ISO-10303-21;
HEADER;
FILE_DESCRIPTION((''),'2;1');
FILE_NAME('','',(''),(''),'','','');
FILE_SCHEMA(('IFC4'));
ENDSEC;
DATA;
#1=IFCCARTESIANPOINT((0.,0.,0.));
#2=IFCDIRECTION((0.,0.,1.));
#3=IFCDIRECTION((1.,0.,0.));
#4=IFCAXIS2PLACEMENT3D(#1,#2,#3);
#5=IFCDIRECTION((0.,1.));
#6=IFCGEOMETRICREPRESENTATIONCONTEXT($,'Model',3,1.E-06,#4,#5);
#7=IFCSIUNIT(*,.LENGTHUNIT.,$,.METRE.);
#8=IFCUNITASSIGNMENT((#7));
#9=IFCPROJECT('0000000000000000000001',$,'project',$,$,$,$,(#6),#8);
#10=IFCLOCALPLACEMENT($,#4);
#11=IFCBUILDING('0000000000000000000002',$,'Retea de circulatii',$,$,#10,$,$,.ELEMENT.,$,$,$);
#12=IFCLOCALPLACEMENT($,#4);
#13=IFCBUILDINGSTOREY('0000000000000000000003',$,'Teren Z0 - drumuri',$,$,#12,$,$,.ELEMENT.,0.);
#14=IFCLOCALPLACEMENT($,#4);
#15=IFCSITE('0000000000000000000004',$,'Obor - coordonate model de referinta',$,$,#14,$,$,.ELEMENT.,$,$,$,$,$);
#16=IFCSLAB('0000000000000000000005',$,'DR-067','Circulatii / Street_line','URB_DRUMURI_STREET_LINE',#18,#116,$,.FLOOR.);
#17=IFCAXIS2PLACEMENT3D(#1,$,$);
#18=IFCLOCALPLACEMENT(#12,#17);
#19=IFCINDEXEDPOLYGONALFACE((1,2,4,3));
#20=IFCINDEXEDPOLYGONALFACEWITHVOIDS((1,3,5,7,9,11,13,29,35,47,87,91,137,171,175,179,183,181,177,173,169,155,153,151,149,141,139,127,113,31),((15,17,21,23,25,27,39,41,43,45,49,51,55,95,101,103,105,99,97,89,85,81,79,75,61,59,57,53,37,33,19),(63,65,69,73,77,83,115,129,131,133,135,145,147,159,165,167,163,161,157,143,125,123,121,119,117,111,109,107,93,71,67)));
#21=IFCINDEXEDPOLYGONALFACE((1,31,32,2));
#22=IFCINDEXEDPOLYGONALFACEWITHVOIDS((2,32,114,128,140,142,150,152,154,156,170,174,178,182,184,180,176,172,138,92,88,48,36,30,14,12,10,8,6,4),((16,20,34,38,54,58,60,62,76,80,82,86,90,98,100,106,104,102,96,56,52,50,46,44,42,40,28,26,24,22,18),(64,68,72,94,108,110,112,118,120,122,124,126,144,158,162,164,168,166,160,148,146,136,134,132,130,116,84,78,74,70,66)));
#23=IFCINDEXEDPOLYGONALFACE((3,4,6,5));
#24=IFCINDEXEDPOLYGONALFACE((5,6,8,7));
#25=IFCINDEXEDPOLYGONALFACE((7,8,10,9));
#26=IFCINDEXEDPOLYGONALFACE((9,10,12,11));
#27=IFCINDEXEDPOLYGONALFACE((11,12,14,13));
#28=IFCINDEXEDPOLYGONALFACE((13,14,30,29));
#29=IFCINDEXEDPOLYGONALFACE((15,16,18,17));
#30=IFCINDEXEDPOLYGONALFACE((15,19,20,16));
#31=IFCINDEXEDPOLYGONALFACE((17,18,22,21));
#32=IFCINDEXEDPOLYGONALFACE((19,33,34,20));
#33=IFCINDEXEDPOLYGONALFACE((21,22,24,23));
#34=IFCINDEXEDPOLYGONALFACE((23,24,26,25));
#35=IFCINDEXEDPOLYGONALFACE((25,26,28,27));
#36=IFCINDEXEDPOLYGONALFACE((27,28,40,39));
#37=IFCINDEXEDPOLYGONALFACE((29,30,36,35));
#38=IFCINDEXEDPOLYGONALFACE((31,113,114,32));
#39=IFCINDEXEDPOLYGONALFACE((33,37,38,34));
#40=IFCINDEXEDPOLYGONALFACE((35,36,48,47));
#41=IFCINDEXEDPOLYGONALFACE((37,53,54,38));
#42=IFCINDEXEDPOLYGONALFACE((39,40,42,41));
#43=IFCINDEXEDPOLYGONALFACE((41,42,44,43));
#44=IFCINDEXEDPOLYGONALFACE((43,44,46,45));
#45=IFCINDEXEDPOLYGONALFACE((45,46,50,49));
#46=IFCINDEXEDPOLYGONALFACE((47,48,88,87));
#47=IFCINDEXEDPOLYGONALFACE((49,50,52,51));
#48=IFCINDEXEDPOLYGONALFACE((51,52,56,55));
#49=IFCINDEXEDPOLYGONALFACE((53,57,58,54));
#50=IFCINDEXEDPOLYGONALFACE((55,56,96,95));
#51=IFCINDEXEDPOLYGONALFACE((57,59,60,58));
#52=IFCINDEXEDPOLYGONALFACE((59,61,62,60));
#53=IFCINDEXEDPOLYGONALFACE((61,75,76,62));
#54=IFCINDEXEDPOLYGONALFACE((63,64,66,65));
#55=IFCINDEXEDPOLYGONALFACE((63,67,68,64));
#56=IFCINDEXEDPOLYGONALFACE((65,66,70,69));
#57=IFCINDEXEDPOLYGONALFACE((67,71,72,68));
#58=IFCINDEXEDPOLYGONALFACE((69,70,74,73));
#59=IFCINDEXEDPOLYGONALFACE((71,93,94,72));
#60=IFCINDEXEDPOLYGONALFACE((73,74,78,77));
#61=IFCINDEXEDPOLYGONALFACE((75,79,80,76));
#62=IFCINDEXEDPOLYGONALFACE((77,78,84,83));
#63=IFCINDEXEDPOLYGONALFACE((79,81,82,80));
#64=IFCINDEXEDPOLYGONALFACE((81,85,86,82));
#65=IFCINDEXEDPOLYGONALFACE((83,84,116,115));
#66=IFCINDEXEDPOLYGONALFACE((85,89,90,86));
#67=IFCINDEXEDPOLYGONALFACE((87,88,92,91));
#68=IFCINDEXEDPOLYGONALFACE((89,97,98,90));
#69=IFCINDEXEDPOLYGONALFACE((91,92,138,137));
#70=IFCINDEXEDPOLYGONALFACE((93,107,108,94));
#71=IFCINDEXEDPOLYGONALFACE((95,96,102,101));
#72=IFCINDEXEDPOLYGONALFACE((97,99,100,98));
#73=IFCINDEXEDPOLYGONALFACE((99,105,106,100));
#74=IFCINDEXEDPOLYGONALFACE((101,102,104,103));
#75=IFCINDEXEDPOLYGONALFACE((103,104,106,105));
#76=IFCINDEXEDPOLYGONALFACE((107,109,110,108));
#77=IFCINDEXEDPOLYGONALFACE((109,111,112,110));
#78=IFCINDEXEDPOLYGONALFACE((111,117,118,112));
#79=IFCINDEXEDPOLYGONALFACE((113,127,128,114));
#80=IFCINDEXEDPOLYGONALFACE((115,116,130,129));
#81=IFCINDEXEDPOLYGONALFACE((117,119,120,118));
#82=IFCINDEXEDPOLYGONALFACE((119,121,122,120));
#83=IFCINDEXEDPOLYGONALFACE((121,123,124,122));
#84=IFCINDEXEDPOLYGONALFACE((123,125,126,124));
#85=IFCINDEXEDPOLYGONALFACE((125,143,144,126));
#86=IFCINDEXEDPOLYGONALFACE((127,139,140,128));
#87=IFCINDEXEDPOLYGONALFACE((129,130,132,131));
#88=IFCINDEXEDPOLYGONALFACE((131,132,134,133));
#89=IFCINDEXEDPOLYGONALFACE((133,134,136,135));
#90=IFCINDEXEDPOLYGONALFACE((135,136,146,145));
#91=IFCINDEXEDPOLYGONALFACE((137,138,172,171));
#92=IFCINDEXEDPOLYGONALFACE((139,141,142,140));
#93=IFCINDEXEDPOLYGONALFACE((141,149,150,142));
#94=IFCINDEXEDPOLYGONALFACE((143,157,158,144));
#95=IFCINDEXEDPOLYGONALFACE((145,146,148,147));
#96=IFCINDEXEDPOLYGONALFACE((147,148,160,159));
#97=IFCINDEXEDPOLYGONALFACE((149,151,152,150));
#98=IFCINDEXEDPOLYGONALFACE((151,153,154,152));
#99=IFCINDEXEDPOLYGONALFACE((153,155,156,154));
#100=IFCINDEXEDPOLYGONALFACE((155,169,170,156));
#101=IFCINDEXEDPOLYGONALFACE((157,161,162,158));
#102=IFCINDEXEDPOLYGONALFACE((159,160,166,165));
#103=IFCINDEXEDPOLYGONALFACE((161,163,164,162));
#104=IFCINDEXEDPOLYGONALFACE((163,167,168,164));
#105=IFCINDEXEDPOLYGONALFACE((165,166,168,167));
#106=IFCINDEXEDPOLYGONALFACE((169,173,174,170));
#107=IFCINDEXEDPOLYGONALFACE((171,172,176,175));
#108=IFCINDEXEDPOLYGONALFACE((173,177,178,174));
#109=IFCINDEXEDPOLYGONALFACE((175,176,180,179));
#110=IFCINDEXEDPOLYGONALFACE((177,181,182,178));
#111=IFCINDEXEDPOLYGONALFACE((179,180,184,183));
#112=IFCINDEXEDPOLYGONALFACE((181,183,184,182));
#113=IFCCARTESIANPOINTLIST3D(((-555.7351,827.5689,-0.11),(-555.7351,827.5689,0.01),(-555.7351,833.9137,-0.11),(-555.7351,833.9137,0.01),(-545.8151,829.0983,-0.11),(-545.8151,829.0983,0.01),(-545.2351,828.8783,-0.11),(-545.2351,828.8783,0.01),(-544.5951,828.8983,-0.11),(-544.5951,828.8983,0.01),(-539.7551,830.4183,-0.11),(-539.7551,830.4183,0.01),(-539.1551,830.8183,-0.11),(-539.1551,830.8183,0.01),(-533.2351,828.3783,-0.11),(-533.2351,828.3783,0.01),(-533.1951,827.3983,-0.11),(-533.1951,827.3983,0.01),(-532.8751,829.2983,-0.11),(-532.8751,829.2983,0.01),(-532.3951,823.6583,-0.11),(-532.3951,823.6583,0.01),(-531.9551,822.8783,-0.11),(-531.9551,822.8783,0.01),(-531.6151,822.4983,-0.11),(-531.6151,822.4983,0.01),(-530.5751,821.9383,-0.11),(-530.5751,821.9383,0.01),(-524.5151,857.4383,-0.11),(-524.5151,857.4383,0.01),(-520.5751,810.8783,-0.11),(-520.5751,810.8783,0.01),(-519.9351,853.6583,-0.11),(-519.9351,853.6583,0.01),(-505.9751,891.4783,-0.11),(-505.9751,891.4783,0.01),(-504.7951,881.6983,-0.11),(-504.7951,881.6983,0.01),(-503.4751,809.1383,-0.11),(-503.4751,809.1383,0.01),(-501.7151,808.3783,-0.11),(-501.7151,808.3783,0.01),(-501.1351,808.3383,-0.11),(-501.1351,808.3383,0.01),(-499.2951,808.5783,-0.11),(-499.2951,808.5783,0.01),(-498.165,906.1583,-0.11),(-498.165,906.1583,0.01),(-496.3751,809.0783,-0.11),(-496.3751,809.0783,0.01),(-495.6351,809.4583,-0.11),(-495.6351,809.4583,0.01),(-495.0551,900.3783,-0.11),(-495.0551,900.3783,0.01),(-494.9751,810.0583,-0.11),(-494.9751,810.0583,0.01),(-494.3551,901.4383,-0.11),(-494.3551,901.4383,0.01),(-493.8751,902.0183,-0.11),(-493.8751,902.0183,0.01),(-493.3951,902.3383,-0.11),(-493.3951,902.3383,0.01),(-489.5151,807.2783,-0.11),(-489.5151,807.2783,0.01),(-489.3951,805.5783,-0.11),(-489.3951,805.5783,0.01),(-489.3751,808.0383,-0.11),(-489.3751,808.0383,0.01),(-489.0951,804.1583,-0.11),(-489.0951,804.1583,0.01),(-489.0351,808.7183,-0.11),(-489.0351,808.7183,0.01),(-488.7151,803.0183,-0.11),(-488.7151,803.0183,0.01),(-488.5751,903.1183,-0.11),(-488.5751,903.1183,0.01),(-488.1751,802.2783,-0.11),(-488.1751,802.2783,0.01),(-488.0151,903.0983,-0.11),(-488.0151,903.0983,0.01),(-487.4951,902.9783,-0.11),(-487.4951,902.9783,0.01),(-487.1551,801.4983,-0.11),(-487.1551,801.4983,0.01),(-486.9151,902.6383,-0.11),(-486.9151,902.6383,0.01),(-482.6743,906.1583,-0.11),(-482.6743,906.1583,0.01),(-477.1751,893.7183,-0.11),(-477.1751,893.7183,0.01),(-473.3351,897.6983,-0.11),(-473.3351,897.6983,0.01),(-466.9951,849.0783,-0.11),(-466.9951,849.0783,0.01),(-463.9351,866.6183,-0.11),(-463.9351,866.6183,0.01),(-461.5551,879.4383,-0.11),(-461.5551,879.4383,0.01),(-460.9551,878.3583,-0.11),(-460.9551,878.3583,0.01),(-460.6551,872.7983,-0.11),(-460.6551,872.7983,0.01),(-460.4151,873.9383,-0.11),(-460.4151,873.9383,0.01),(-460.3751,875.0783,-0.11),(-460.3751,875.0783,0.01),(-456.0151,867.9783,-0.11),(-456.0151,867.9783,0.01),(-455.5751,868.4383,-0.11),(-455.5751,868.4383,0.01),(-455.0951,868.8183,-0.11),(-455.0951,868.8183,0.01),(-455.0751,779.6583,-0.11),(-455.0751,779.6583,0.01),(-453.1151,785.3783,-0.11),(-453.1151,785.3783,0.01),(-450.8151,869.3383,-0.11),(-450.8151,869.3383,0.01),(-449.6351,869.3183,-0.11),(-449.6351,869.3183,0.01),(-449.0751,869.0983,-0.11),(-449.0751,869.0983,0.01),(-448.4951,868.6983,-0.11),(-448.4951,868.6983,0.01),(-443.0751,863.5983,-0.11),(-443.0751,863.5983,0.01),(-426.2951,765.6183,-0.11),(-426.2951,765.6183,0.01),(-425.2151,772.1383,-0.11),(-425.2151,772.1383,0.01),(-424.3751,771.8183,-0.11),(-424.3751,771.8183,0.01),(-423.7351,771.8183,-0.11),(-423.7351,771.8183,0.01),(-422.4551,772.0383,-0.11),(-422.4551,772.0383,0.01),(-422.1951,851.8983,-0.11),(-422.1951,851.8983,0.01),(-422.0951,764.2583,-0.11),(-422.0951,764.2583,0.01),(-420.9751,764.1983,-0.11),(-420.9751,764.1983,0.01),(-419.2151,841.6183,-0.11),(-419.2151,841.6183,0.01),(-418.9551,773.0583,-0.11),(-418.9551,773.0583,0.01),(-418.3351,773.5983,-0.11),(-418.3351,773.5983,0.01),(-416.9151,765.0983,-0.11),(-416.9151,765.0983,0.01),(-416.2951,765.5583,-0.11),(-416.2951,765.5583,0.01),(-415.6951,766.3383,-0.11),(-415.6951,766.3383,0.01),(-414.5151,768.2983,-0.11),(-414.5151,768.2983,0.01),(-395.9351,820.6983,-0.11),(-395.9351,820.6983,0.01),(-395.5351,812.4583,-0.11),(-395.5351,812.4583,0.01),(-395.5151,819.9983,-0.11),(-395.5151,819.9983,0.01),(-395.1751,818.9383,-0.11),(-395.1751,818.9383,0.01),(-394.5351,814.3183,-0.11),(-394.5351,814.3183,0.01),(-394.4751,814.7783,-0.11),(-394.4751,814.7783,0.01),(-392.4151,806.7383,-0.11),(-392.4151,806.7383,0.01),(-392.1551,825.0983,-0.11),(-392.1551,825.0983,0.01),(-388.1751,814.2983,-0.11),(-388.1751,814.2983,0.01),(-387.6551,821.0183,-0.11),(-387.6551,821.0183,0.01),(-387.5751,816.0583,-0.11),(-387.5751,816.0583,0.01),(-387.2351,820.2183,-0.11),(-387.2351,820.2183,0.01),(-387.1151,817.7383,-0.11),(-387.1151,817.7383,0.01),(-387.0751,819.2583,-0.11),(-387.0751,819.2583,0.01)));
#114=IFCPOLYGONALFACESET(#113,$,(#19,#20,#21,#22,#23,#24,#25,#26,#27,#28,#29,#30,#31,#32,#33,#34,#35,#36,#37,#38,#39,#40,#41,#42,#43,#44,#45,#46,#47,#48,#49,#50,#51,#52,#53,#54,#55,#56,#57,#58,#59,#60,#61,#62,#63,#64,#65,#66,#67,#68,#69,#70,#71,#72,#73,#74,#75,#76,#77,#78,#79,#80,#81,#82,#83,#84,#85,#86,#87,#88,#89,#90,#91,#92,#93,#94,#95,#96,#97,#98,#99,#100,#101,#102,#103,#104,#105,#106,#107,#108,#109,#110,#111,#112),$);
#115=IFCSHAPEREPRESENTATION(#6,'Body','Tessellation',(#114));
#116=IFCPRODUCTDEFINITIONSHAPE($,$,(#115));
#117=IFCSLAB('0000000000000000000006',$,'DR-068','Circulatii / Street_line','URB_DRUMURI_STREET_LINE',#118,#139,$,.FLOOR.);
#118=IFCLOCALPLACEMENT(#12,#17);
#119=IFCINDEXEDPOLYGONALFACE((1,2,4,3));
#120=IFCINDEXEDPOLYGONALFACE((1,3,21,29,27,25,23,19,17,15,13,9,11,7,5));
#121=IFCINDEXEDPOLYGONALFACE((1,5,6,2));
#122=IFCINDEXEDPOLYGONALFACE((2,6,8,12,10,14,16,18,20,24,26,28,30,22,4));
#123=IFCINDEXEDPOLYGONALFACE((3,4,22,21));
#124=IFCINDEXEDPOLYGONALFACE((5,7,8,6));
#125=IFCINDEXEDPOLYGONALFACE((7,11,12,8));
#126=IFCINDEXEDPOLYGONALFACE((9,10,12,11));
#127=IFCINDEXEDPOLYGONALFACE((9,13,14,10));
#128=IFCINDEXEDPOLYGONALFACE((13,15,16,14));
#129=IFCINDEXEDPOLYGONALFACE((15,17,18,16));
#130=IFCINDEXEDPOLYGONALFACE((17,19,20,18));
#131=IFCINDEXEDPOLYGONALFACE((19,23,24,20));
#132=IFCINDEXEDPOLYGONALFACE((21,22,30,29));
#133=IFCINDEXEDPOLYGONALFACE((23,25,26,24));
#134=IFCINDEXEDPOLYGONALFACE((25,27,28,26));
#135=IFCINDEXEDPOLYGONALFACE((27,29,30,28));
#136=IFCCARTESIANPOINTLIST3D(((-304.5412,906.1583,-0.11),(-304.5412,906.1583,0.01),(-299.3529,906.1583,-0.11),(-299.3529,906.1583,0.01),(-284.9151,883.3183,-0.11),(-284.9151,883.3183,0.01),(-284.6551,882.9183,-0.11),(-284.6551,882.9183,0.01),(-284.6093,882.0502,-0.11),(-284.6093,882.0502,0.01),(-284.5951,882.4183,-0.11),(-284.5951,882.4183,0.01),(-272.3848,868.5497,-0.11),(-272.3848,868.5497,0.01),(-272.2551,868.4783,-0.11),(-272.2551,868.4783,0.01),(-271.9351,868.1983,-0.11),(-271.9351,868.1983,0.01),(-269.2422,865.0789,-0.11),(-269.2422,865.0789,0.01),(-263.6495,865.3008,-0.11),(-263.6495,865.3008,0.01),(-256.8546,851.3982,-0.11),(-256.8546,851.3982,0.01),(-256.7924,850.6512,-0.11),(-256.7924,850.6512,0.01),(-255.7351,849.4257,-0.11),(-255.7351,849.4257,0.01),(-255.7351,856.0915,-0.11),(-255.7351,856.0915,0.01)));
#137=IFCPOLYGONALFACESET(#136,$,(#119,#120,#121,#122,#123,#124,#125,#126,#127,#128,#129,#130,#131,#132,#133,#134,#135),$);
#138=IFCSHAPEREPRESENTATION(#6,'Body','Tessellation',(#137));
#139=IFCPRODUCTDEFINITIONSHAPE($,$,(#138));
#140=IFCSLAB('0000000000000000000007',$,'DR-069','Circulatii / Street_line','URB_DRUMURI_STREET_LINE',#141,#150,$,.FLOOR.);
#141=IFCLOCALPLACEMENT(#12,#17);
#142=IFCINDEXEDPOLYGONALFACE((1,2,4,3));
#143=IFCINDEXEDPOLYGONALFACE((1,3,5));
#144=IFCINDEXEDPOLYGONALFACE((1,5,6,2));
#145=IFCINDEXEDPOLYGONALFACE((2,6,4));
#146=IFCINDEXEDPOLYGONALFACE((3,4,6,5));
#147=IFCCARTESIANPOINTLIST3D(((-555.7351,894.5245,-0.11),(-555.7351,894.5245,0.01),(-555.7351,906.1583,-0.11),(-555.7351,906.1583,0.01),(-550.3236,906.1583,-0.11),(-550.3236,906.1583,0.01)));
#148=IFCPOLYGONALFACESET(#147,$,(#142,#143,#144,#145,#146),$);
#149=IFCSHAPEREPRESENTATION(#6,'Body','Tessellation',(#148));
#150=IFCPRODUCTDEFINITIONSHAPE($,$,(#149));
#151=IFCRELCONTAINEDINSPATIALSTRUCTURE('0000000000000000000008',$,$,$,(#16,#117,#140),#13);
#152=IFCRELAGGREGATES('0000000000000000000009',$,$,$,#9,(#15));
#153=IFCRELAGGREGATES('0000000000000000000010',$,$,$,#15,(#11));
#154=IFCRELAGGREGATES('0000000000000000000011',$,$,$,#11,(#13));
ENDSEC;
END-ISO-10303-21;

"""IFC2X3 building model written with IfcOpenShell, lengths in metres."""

from ifc_helpers import new_model, si_unit, direction, frame, origin_with_axes, place, context, project, spatial, polyline, outline, extrude, element, save


model = new_model("IFC2X3")

# Units and contexts
model_context = context("Model", 3, precision=1e-06, world=origin_with_axes(), true_north=direction((0.0, 1.0)))
ifc_project = project(units=[si_unit("LENGTHUNIT", "METRE")], contexts=[model_context])

# Site, building, storey
site_placement = place(None, origin_with_axes())
site = spatial("IfcSite", under=ifc_project, at=site_placement, Name="Obor - coordonate model de referinta", CompositionType="ELEMENT")
building_placement = place(None, origin_with_axes())
building = spatial("IfcBuilding", under=site, at=building_placement, Name="Retea de circulatii", CompositionType="ELEMENT")
storey_placement = place(None, origin_with_axes())
storey = spatial("IfcBuildingStorey", under=building, at=storey_placement, Name="Teren Z0 - drumuri", CompositionType="ELEMENT", Elevation=0.0)

# Slabs
slab_1_placement = place(None, origin_with_axes())
element("IfcSlab", 1, at=slab_1_placement, inside=storey, Name="DR-067", Description="Circulatii / Street_line", ObjectType="URB_DRUMURI_STREET_LINE", PredefinedType="FLOOR", context=model_context, shape_type="SweptSolid", body=[
    extrude(outline(polyline([(-555.7351, 827.5689), (-520.5751, 810.8783), (-455.0751, 779.6583), (-426.2951, 765.6183), (-422.0951, 764.2583), (-420.9751, 764.1983), (-416.9151, 765.0983), (-416.2951, 765.5583), (-415.6951, 766.3383), (-414.5151, 768.2983), (-392.4151, 806.7383), (-388.1751, 814.2983), (-387.5751, 816.0583), (-387.1151, 817.7383), (-387.0751, 819.2583), (-387.2351, 820.2183), (-387.6551, 821.0183), (-392.1551, 825.0983), (-422.1951, 851.8983), (-473.3351, 897.6983), (-482.6743, 906.1583), (-498.165, 906.1583), (-505.9751, 891.4783), (-524.5151, 857.4383), (-539.1551, 830.8183), (-539.7551, 830.4183), (-544.5951, 828.8983), (-545.2351, 828.8783), (-545.8151, 829.0983), (-555.7351, 833.9137), (-555.7351, 827.5689)]), holes=[polyline([(-449.0751, 869.0983), (-448.4951, 868.6983), (-443.0751, 863.5983), (-419.2151, 841.6183), (-395.9351, 820.6983), (-395.5151, 819.9983), (-395.1751, 818.9383), (-394.4751, 814.7783), (-394.5351, 814.3183), (-395.5351, 812.4583), (-418.3351, 773.5983), (-418.9551, 773.0583), (-422.4551, 772.0383), (-423.7351, 771.8183), (-424.3751, 771.8183), (-425.2151, 772.1383), (-453.1151, 785.3783), (-487.1551, 801.4983), (-488.1751, 802.2783), (-488.7151, 803.0183), (-489.0951, 804.1583), (-489.3951, 805.5783), (-489.5151, 807.2783), (-489.3751, 808.0383), (-489.0351, 808.7183), (-466.9951, 849.0783), (-456.0151, 867.9783), (-455.5751, 868.4383), (-455.0951, 868.8183), (-450.8151, 869.3383), (-449.6351, 869.3183), (-449.0751, 869.0983)]), polyline([(-501.7151, 808.3783), (-503.4751, 809.1383), (-530.5751, 821.9383), (-531.6151, 822.4983), (-531.9551, 822.8783), (-532.3951, 823.6583), (-533.1951, 827.3983), (-533.2351, 828.3783), (-532.8751, 829.2983), (-519.9351, 853.6583), (-504.7951, 881.6983), (-495.0551, 900.3783), (-494.3551, 901.4383), (-493.8751, 902.0183), (-493.3951, 902.3383), (-488.5751, 903.1183), (-488.0151, 903.0983), (-487.4951, 902.9783), (-486.9151, 902.6383), (-477.1751, 893.7183), (-461.5551, 879.4383), (-460.9551, 878.3583), (-460.3751, 875.0783), (-460.4151, 873.9383), (-460.6551, 872.7983), (-463.9351, 866.6183), (-494.9751, 810.0583), (-495.6351, 809.4583), (-496.3751, 809.0783), (-499.2951, 808.5783), (-501.1351, 808.3383), (-501.7151, 808.3783)])]), frame((0.0, 0.0, -0.11), z_axis=(0.0, 0.0, 1.0), x_axis=(1.0, 0.0, 0.0)), (0.0, 0.0, 1.0), 0.12),
])
slab_2_placement = place(None, origin_with_axes())
element("IfcSlab", 2, at=slab_2_placement, inside=storey, Name="DR-068", Description="Circulatii / Street_line", ObjectType="URB_DRUMURI_STREET_LINE", PredefinedType="FLOOR", context=model_context, shape_type="SweptSolid", body=[
    extrude(outline(polyline([(-256.7924, 850.6512), (-255.7351, 849.4257), (-255.7351, 856.0915), (-263.6495, 865.3008), (-299.3529, 906.1583), (-304.5412, 906.1583), (-284.9151, 883.3183), (-284.6551, 882.9183), (-284.5951, 882.4183), (-284.6093, 882.0502), (-272.3848, 868.5497), (-272.2551, 868.4783), (-271.9351, 868.1983), (-269.2422, 865.0789), (-256.8546, 851.3982), (-256.7924, 850.6512)])), frame((0.0, 0.0, -0.11), z_axis=(0.0, 0.0, 1.0), x_axis=(1.0, 0.0, 0.0)), (0.0, 0.0, 1.0), 0.12),
])
slab_3_placement = place(None, origin_with_axes())
element("IfcSlab", 3, at=slab_3_placement, inside=storey, Name="DR-069", Description="Circulatii / Street_line", ObjectType="URB_DRUMURI_STREET_LINE", PredefinedType="FLOOR", context=model_context, shape_type="SweptSolid", body=[
    extrude(outline(polyline([(-555.7351, 894.5245), (-550.3236, 906.1583), (-555.7351, 906.1583), (-555.7351, 894.5245)])), frame((0.0, 0.0, -0.11), z_axis=(0.0, 0.0, 1.0), x_axis=(1.0, 0.0, 0.0)), (0.0, 0.0, 1.0), 0.12),
])

save(model, "model.ifc")
